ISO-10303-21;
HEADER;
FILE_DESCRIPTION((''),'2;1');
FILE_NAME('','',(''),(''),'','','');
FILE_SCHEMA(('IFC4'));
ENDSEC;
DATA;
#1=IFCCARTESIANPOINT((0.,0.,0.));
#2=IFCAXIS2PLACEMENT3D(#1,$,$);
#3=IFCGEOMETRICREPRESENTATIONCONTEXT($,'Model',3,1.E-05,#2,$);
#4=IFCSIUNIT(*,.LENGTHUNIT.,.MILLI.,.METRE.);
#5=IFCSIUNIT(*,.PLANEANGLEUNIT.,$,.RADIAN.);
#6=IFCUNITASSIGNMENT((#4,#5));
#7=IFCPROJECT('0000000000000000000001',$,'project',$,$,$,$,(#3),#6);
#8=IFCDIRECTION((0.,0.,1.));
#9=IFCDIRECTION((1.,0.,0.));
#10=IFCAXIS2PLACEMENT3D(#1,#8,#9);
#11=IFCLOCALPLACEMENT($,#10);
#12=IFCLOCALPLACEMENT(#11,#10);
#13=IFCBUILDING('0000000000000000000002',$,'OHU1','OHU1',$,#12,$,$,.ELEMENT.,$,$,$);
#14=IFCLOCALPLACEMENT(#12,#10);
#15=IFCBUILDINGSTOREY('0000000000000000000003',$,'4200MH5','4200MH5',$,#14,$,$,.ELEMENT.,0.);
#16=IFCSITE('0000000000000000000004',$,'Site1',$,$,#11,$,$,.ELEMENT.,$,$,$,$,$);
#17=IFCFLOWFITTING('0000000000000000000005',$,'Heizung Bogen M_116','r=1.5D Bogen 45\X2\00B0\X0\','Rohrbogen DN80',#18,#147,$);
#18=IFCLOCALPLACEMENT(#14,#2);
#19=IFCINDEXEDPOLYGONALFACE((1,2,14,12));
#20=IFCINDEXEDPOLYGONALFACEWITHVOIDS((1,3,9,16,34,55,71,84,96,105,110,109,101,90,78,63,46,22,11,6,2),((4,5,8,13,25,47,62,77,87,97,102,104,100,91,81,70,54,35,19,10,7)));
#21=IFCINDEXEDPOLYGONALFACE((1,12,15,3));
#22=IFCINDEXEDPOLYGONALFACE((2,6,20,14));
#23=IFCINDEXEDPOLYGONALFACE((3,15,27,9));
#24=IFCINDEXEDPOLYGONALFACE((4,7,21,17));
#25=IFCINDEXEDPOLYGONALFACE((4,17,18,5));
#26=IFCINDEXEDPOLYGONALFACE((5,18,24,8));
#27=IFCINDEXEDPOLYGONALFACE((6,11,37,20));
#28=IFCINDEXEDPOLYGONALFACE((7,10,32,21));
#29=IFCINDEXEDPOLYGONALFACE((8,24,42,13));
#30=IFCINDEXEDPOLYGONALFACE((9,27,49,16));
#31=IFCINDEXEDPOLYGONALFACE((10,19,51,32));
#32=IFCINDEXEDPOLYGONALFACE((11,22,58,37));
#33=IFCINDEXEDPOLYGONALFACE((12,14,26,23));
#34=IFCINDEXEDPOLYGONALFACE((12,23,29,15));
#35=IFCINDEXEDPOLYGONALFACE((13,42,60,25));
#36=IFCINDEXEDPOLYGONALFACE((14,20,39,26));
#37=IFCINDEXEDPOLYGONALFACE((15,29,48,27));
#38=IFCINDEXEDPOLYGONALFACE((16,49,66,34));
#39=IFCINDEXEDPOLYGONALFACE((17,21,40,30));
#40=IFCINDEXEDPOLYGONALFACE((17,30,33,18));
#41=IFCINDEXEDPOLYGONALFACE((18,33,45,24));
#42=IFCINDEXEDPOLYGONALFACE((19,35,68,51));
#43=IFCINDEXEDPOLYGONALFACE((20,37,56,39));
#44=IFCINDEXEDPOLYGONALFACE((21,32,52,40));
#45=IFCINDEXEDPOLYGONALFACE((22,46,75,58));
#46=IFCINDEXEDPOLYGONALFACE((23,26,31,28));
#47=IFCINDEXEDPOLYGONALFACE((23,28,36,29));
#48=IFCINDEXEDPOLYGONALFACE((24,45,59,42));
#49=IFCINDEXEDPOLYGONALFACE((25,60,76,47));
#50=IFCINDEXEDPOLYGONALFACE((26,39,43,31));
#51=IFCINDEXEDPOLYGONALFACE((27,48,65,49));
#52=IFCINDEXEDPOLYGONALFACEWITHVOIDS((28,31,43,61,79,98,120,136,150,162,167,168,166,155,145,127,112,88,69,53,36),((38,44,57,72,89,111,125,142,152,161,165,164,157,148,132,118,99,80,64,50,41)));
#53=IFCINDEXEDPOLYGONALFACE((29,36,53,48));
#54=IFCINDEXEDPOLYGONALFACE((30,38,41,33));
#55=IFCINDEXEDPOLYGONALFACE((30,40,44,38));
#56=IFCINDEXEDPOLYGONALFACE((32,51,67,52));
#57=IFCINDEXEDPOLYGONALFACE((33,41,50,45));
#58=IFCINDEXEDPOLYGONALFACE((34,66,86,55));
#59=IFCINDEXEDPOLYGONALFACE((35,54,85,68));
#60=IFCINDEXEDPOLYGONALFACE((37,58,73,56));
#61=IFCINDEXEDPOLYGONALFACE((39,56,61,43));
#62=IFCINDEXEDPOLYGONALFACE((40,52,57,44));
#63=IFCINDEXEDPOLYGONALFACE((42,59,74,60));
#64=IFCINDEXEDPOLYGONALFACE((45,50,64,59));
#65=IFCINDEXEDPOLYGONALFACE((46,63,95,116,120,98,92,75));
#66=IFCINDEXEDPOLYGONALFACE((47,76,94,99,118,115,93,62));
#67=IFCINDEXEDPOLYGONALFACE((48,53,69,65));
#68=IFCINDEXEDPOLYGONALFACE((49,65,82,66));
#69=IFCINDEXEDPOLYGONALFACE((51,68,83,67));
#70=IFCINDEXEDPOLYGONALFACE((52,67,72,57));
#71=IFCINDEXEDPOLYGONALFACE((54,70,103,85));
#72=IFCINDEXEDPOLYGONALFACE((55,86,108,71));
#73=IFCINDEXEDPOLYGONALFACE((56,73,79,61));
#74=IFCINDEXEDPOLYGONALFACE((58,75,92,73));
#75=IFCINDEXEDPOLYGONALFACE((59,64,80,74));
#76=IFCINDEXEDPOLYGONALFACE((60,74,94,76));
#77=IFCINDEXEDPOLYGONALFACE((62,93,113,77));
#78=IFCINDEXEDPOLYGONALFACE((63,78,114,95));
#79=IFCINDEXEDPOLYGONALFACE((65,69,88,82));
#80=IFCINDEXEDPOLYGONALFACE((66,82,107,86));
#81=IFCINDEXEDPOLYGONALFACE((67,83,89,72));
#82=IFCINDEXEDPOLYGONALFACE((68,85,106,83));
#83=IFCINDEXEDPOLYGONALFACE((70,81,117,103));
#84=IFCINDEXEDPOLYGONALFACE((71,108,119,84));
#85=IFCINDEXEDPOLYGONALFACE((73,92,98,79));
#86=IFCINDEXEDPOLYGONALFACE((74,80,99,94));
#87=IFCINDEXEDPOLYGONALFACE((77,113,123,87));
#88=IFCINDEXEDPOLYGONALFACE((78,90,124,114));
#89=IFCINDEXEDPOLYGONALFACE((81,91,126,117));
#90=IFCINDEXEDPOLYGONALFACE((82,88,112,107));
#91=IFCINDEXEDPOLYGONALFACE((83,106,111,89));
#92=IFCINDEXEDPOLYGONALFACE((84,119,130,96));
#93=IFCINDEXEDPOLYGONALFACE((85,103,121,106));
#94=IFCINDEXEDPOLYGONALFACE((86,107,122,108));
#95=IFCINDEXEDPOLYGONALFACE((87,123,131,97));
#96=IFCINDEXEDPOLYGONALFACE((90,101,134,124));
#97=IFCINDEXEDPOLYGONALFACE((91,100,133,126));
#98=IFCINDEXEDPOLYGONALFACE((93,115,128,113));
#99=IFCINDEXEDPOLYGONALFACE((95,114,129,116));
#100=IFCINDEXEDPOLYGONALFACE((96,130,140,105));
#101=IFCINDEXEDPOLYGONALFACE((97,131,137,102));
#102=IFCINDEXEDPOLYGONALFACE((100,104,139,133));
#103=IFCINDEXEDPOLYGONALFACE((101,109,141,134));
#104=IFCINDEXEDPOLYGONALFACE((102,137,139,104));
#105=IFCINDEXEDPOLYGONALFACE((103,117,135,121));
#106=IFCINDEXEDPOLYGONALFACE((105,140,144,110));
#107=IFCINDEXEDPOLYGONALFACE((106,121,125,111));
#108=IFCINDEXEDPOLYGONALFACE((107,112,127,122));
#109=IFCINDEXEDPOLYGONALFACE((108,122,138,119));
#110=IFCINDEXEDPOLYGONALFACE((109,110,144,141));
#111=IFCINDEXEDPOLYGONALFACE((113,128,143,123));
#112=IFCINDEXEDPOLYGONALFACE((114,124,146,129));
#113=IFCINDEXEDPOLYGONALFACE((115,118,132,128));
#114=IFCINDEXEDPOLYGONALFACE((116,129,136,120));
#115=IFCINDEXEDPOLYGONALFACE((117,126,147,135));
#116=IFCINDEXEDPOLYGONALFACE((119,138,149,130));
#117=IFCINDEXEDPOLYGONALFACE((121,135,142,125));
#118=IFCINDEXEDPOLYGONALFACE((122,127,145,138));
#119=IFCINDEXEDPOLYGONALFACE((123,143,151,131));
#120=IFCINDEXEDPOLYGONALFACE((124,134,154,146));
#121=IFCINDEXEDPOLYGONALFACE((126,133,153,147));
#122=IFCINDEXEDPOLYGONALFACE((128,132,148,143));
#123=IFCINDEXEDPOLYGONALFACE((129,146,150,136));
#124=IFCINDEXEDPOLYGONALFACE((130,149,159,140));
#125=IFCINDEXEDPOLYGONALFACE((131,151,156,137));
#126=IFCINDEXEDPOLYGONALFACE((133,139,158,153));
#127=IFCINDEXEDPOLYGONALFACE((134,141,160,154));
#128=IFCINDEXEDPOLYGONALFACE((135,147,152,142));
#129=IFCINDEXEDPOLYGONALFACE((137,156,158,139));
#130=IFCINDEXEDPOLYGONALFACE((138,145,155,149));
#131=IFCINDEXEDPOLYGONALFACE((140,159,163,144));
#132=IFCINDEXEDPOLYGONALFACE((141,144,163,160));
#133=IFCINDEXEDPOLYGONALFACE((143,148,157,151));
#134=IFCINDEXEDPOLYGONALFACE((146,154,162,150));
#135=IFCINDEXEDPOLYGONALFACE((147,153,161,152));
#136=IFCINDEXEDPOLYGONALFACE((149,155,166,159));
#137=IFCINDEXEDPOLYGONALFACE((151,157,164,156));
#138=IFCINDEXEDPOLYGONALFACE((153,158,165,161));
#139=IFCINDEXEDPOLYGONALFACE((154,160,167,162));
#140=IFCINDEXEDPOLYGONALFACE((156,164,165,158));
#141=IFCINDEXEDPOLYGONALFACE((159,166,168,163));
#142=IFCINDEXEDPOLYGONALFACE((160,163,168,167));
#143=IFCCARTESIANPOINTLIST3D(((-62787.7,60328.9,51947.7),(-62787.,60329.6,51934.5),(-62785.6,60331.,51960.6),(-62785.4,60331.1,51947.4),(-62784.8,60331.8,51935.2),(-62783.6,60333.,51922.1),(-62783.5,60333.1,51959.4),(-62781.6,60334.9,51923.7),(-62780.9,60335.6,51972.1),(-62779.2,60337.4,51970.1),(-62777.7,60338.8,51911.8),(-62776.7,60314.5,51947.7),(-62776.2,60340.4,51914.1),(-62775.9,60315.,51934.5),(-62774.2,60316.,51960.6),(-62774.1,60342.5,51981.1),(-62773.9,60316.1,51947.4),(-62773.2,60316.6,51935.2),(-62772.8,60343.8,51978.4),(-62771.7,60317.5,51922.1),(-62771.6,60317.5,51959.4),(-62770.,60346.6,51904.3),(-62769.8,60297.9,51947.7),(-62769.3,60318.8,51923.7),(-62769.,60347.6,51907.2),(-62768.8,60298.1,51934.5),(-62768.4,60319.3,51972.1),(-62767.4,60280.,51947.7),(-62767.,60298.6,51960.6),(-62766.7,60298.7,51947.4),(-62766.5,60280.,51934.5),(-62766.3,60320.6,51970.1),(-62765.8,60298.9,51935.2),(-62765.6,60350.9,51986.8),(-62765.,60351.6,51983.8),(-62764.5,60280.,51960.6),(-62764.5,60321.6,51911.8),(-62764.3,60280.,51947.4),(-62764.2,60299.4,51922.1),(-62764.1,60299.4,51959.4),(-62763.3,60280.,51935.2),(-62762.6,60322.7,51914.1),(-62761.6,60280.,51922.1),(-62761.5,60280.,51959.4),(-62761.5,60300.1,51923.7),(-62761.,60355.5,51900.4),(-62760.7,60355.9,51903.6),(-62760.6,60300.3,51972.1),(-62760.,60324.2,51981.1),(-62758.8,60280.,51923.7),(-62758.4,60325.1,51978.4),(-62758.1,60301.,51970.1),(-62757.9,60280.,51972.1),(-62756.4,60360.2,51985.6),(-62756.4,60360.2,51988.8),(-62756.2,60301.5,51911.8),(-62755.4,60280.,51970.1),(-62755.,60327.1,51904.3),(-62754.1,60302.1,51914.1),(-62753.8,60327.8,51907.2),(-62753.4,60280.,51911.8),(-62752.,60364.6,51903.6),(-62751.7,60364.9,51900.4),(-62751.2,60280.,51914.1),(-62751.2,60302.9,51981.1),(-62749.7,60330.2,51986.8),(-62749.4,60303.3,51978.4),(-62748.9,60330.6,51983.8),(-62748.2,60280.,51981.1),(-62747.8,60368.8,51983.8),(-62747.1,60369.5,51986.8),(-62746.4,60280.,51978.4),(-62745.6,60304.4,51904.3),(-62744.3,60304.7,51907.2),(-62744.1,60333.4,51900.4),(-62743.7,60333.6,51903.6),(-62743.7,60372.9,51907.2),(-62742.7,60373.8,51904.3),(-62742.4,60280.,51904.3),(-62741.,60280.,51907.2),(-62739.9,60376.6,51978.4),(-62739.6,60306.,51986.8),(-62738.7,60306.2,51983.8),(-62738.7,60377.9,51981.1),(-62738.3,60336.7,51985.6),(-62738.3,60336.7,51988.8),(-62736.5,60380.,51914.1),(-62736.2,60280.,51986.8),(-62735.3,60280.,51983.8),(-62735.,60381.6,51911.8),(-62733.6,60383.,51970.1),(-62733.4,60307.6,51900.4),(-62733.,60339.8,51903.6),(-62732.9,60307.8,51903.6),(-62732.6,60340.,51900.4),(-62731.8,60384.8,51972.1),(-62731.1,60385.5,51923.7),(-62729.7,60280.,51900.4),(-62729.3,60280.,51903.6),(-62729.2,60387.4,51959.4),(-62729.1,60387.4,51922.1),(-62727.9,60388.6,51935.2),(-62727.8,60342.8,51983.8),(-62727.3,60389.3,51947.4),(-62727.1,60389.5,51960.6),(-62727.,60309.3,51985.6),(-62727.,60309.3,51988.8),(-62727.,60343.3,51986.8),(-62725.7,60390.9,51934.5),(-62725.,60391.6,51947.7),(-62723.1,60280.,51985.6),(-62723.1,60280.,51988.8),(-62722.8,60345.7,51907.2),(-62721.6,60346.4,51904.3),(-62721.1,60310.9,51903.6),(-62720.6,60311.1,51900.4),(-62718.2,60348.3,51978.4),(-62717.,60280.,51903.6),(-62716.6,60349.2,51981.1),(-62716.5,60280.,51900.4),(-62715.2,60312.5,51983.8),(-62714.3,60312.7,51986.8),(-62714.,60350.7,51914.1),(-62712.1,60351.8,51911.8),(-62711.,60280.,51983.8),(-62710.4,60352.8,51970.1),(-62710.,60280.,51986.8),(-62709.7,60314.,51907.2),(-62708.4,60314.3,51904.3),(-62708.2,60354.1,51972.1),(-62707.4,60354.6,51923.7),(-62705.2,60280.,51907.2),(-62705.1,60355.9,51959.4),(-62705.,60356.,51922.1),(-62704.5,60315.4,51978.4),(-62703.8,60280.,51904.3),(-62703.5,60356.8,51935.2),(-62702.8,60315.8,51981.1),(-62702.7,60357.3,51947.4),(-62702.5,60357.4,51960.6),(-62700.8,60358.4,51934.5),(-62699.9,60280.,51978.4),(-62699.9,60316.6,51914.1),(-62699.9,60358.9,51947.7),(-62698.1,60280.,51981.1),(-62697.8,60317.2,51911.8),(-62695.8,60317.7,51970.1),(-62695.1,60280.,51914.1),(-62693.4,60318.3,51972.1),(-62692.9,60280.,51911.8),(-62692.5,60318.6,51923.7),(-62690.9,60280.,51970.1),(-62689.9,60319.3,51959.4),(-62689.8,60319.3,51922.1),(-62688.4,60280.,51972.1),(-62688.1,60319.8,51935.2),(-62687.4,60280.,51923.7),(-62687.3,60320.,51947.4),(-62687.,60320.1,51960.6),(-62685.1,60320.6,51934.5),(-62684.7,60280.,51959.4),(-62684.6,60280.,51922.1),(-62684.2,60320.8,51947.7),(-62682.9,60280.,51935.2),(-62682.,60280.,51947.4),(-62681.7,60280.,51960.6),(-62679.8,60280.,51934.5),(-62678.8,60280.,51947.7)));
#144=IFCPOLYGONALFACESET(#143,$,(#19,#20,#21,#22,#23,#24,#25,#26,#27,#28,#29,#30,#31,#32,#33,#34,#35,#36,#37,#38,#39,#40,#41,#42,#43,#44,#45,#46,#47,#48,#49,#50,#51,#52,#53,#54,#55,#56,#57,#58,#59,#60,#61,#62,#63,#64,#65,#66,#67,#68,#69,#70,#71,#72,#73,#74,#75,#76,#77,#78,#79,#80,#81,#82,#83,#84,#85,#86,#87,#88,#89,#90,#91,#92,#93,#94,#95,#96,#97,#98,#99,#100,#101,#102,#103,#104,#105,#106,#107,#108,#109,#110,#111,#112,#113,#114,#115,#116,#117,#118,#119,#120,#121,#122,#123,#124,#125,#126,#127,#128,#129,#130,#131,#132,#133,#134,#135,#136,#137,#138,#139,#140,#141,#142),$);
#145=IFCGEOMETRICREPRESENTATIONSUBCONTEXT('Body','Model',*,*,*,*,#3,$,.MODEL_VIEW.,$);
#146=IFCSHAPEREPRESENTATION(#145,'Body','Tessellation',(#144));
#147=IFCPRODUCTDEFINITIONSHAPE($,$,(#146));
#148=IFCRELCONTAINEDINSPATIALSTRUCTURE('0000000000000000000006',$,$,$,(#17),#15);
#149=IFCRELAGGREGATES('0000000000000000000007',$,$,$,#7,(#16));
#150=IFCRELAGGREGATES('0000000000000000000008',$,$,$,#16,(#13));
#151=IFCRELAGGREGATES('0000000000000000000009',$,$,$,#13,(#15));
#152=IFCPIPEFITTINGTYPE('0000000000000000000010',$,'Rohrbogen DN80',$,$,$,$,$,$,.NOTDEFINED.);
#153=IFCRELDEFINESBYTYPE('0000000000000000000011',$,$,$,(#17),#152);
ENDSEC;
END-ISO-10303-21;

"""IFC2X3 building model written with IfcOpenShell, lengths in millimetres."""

from ifc_helpers import new_model, entity, si_unit, frame, origin, origin_with_axes, place, context, subcontext, project, spatial, type_object, element, save


model = new_model("IFC2X3")

# Units and contexts
model_context = context("Model", 3, precision=1e-05, world=origin())
body_context = subcontext(model_context, "Body", "Model", "MODEL_VIEW")
ifc_project = project(units=[si_unit("LENGTHUNIT", "METRE", prefix="MILLI"), si_unit("PLANEANGLEUNIT", "RADIAN")], contexts=[model_context])

# Site, building, storey
site_placement = place(None, origin_with_axes())
site = spatial("IfcSite", under=ifc_project, at=site_placement, Name="Site1", CompositionType="ELEMENT")
building_placement = place(site_placement, origin_with_axes())
building = spatial("IfcBuilding", under=site, at=building_placement, Name="OHU1", Description="OHU1", CompositionType="ELEMENT")
storey_placement = place(building_placement, origin_with_axes())
storey = spatial("IfcBuildingStorey", under=building, at=storey_placement, Name="4200MH5", Description="4200MH5", CompositionType="ELEMENT", Elevation=0.0)

# Flow fitting
pipe_fitting_type_1 = type_object("IfcPipeFittingType", Name="Rohrbogen DN80", PredefinedType="NOTDEFINED")
flow_fitting_1_placement = place(storey_placement, frame((-62699.7, 60303.6, 51944.4), z_axis=(0.0, 0.0, 1.0), x_axis=(1.0, 0.0, 0.0)))
element("IfcFlowFitting", 1, at=flow_fitting_1_placement, inside=storey, type_object=pipe_fitting_type_1, Name="Heizung Bogen M_116", Description="r=1.5D Bogen 45°", ObjectType="Rohrbogen DN80", context=body_context, shape_type="SweptSolid", body=[
    entity("IfcRevolvedAreaSolid", entity("IfcCircleHollowProfileDef", "AREA", None, entity("IfcAxis2Placement2D", entity("IfcCartesianPoint", [0.0, 0.0]), entity("IfcDirection", [1.0, 0.0])), 44.5, 3.2), entity("IfcAxis2Placement3D", entity("IfcCartesianPoint", [-56.6, 56.6, 0.0]), entity("IfcDirection", [0.707104, -0.707109, 0.0]), entity("IfcDirection", [0.0, 0.0, 1.0])), entity("IfcAxis1Placement", entity("IfcCartesianPoint", [0.0, 113.5, 0.0]), entity("IfcDirection", [-1.0, 0.0, 0.0])), 0.785398),
])

save(model, "model.ifc")
